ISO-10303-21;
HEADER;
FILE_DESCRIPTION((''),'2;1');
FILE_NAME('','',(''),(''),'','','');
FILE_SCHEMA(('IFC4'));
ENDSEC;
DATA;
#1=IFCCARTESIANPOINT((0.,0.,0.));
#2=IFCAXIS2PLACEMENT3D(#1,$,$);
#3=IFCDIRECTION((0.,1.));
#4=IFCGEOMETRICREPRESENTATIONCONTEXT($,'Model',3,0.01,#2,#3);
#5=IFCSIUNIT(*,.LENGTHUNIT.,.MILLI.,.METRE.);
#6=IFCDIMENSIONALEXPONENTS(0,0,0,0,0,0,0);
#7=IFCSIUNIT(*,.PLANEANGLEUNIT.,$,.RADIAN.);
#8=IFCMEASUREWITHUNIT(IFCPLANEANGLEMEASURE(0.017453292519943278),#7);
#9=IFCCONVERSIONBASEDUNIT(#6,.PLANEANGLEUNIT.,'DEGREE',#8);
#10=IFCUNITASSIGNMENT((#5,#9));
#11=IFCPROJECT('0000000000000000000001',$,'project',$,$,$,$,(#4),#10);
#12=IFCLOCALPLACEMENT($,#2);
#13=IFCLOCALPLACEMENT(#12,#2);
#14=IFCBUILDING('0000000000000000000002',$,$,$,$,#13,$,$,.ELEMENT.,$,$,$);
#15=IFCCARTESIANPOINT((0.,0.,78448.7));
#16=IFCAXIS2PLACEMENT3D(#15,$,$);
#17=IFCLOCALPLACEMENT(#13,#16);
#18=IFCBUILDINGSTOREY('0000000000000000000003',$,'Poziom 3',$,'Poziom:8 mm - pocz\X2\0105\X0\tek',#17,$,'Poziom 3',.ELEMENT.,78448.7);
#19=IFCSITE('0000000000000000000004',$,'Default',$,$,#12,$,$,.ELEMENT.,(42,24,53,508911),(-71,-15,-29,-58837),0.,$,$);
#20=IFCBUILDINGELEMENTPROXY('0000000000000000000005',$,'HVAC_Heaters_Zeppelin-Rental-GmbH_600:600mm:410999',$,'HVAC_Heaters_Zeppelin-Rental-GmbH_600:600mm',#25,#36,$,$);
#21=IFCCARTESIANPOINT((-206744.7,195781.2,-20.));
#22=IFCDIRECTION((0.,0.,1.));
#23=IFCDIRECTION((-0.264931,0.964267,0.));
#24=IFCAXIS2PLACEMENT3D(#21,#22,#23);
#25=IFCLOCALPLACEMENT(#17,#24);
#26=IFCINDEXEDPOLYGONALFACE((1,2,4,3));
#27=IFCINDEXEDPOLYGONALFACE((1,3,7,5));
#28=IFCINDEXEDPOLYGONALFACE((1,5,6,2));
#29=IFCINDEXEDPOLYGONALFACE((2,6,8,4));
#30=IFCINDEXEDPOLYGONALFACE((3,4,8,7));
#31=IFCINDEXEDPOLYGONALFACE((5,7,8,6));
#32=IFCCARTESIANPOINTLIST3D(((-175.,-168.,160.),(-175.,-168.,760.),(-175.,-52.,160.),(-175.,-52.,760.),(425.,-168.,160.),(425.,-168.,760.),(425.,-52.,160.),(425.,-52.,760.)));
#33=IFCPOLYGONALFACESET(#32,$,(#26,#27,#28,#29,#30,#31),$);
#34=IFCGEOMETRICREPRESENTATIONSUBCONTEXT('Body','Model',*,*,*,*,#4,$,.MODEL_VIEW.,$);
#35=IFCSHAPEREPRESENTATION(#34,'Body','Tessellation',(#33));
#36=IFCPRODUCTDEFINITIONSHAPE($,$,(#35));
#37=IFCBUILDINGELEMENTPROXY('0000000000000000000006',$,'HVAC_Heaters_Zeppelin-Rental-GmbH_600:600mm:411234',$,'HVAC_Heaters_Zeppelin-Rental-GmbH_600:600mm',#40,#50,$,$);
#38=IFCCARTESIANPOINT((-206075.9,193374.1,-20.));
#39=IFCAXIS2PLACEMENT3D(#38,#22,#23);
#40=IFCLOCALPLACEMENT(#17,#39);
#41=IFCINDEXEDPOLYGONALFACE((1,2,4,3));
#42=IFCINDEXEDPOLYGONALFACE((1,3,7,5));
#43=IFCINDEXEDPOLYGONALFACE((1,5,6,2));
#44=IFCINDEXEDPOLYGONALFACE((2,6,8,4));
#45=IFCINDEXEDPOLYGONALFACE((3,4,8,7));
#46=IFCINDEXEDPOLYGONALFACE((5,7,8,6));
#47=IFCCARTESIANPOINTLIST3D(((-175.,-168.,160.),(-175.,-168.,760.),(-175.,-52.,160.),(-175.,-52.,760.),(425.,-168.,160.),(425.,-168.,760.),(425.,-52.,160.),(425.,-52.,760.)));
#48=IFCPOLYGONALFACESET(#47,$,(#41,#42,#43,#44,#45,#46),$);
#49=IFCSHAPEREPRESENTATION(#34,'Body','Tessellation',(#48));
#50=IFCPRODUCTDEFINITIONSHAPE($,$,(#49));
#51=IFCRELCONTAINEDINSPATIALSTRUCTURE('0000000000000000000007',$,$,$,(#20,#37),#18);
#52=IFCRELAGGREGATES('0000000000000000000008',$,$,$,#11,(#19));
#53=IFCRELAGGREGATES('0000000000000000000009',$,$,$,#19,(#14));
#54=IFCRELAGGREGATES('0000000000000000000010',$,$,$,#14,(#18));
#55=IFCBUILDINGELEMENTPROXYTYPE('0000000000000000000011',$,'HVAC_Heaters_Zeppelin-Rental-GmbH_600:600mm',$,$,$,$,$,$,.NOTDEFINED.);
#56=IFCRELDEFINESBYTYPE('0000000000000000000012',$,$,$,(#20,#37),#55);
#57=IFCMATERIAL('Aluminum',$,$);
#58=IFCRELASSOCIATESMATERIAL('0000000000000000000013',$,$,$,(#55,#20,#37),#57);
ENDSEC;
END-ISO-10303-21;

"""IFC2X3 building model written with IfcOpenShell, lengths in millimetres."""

from ifc_helpers import new_model, entity, si_unit, converted_unit, direction, frame, frame_2d, origin, place, context, subcontext, project, spatial, rectangle, extrude, source, transform, mapped, material, type_object, type_shapes, element, save


model = new_model("IFC2X3")

# Units and contexts
model_context = context("Model", 3, precision=0.01, world=origin(), true_north=direction((0.0, 1.0)))
body_context = subcontext(model_context, "Body", "Model", "MODEL_VIEW")
ifc_project = project(units=[si_unit("LENGTHUNIT", "METRE", prefix="MILLI"), converted_unit("PLANEANGLEUNIT", "DEGREE", entity("IfcPlaneAngleMeasure", 0.017453292519943278), si_unit("PLANEANGLEUNIT", "RADIAN"), dimensions=[0, 0, 0, 0, 0, 0, 0])], contexts=[model_context])

# Site, building, storey
site_placement = place(None, origin())
site = spatial("IfcSite", under=ifc_project, at=site_placement, Name="Default", CompositionType="ELEMENT", RefLatitude=(42, 24, 53, 508911), RefLongitude=(-71, -15, -29, -58837), RefElevation=0.0)
building_placement = place(site_placement, origin())
building = spatial("IfcBuilding", under=site, at=building_placement, CompositionType="ELEMENT")
storey_placement = place(building_placement, frame((0.0, 0.0, 78448.7)))
storey = spatial("IfcBuildingStorey", under=building, at=storey_placement, Name="Poziom 3", ObjectType="Poziom:8 mm - początek", LongName="Poziom 3", CompositionType="ELEMENT", Elevation=78448.7)

# Shared definitions
ifc_material_1 = material(Name="Aluminum")

# Building element proxies
building_element_proxy_type = type_object("IfcBuildingElementProxyType", Name="HVAC_Heaters_Zeppelin-Rental-GmbH_600:600mm", PredefinedType="NOTDEFINED", material=ifc_material_1)
shared_shape_1 = source(origin(), body_context, "Body", "SweptSolid", [
    extrude(rectangle(XDim=116.0, YDim=600.0, at=frame_2d((0.0, 0.0), x_axis=(1.0, 0.0))), frame((125.0, -110.0, 160.0), z_axis=(0.0, 0.0, 1.0), x_axis=(0.0, 1.0, 0.0)), (0.0, 0.0, 1.0), 600.0),
])
type_shapes(building_element_proxy_type, [shared_shape_1])
for number, where, z_axis, x_axis, name in (
    (1, (-206744.7, 195781.2, -20.0), (0.0, 0.0, 1.0), (-0.264931, 0.964267, 0.0), "HVAC_Heaters_Zeppelin-Rental-GmbH_600:600mm:410999"),
    (2, (-206075.9, 193374.1, -20.0), (0.0, 0.0, 1.0), (-0.264931, 0.964267, 0.0), "HVAC_Heaters_Zeppelin-Rental-GmbH_600:600mm:411234"),
):
    element("IfcBuildingElementProxy", number, at=place(storey_placement, frame(where, z_axis=z_axis, x_axis=x_axis)), inside=storey, type_object=building_element_proxy_type, material=ifc_material_1, Name=name, ObjectType="HVAC_Heaters_Zeppelin-Rental-GmbH_600:600mm", context=body_context, shape_type="MappedRepresentation", body=[
        mapped(shared_shape_1, transform((0.0, 0.0, 0.0), scale=1.0)),
    ])

save(model, "model.ifc")
